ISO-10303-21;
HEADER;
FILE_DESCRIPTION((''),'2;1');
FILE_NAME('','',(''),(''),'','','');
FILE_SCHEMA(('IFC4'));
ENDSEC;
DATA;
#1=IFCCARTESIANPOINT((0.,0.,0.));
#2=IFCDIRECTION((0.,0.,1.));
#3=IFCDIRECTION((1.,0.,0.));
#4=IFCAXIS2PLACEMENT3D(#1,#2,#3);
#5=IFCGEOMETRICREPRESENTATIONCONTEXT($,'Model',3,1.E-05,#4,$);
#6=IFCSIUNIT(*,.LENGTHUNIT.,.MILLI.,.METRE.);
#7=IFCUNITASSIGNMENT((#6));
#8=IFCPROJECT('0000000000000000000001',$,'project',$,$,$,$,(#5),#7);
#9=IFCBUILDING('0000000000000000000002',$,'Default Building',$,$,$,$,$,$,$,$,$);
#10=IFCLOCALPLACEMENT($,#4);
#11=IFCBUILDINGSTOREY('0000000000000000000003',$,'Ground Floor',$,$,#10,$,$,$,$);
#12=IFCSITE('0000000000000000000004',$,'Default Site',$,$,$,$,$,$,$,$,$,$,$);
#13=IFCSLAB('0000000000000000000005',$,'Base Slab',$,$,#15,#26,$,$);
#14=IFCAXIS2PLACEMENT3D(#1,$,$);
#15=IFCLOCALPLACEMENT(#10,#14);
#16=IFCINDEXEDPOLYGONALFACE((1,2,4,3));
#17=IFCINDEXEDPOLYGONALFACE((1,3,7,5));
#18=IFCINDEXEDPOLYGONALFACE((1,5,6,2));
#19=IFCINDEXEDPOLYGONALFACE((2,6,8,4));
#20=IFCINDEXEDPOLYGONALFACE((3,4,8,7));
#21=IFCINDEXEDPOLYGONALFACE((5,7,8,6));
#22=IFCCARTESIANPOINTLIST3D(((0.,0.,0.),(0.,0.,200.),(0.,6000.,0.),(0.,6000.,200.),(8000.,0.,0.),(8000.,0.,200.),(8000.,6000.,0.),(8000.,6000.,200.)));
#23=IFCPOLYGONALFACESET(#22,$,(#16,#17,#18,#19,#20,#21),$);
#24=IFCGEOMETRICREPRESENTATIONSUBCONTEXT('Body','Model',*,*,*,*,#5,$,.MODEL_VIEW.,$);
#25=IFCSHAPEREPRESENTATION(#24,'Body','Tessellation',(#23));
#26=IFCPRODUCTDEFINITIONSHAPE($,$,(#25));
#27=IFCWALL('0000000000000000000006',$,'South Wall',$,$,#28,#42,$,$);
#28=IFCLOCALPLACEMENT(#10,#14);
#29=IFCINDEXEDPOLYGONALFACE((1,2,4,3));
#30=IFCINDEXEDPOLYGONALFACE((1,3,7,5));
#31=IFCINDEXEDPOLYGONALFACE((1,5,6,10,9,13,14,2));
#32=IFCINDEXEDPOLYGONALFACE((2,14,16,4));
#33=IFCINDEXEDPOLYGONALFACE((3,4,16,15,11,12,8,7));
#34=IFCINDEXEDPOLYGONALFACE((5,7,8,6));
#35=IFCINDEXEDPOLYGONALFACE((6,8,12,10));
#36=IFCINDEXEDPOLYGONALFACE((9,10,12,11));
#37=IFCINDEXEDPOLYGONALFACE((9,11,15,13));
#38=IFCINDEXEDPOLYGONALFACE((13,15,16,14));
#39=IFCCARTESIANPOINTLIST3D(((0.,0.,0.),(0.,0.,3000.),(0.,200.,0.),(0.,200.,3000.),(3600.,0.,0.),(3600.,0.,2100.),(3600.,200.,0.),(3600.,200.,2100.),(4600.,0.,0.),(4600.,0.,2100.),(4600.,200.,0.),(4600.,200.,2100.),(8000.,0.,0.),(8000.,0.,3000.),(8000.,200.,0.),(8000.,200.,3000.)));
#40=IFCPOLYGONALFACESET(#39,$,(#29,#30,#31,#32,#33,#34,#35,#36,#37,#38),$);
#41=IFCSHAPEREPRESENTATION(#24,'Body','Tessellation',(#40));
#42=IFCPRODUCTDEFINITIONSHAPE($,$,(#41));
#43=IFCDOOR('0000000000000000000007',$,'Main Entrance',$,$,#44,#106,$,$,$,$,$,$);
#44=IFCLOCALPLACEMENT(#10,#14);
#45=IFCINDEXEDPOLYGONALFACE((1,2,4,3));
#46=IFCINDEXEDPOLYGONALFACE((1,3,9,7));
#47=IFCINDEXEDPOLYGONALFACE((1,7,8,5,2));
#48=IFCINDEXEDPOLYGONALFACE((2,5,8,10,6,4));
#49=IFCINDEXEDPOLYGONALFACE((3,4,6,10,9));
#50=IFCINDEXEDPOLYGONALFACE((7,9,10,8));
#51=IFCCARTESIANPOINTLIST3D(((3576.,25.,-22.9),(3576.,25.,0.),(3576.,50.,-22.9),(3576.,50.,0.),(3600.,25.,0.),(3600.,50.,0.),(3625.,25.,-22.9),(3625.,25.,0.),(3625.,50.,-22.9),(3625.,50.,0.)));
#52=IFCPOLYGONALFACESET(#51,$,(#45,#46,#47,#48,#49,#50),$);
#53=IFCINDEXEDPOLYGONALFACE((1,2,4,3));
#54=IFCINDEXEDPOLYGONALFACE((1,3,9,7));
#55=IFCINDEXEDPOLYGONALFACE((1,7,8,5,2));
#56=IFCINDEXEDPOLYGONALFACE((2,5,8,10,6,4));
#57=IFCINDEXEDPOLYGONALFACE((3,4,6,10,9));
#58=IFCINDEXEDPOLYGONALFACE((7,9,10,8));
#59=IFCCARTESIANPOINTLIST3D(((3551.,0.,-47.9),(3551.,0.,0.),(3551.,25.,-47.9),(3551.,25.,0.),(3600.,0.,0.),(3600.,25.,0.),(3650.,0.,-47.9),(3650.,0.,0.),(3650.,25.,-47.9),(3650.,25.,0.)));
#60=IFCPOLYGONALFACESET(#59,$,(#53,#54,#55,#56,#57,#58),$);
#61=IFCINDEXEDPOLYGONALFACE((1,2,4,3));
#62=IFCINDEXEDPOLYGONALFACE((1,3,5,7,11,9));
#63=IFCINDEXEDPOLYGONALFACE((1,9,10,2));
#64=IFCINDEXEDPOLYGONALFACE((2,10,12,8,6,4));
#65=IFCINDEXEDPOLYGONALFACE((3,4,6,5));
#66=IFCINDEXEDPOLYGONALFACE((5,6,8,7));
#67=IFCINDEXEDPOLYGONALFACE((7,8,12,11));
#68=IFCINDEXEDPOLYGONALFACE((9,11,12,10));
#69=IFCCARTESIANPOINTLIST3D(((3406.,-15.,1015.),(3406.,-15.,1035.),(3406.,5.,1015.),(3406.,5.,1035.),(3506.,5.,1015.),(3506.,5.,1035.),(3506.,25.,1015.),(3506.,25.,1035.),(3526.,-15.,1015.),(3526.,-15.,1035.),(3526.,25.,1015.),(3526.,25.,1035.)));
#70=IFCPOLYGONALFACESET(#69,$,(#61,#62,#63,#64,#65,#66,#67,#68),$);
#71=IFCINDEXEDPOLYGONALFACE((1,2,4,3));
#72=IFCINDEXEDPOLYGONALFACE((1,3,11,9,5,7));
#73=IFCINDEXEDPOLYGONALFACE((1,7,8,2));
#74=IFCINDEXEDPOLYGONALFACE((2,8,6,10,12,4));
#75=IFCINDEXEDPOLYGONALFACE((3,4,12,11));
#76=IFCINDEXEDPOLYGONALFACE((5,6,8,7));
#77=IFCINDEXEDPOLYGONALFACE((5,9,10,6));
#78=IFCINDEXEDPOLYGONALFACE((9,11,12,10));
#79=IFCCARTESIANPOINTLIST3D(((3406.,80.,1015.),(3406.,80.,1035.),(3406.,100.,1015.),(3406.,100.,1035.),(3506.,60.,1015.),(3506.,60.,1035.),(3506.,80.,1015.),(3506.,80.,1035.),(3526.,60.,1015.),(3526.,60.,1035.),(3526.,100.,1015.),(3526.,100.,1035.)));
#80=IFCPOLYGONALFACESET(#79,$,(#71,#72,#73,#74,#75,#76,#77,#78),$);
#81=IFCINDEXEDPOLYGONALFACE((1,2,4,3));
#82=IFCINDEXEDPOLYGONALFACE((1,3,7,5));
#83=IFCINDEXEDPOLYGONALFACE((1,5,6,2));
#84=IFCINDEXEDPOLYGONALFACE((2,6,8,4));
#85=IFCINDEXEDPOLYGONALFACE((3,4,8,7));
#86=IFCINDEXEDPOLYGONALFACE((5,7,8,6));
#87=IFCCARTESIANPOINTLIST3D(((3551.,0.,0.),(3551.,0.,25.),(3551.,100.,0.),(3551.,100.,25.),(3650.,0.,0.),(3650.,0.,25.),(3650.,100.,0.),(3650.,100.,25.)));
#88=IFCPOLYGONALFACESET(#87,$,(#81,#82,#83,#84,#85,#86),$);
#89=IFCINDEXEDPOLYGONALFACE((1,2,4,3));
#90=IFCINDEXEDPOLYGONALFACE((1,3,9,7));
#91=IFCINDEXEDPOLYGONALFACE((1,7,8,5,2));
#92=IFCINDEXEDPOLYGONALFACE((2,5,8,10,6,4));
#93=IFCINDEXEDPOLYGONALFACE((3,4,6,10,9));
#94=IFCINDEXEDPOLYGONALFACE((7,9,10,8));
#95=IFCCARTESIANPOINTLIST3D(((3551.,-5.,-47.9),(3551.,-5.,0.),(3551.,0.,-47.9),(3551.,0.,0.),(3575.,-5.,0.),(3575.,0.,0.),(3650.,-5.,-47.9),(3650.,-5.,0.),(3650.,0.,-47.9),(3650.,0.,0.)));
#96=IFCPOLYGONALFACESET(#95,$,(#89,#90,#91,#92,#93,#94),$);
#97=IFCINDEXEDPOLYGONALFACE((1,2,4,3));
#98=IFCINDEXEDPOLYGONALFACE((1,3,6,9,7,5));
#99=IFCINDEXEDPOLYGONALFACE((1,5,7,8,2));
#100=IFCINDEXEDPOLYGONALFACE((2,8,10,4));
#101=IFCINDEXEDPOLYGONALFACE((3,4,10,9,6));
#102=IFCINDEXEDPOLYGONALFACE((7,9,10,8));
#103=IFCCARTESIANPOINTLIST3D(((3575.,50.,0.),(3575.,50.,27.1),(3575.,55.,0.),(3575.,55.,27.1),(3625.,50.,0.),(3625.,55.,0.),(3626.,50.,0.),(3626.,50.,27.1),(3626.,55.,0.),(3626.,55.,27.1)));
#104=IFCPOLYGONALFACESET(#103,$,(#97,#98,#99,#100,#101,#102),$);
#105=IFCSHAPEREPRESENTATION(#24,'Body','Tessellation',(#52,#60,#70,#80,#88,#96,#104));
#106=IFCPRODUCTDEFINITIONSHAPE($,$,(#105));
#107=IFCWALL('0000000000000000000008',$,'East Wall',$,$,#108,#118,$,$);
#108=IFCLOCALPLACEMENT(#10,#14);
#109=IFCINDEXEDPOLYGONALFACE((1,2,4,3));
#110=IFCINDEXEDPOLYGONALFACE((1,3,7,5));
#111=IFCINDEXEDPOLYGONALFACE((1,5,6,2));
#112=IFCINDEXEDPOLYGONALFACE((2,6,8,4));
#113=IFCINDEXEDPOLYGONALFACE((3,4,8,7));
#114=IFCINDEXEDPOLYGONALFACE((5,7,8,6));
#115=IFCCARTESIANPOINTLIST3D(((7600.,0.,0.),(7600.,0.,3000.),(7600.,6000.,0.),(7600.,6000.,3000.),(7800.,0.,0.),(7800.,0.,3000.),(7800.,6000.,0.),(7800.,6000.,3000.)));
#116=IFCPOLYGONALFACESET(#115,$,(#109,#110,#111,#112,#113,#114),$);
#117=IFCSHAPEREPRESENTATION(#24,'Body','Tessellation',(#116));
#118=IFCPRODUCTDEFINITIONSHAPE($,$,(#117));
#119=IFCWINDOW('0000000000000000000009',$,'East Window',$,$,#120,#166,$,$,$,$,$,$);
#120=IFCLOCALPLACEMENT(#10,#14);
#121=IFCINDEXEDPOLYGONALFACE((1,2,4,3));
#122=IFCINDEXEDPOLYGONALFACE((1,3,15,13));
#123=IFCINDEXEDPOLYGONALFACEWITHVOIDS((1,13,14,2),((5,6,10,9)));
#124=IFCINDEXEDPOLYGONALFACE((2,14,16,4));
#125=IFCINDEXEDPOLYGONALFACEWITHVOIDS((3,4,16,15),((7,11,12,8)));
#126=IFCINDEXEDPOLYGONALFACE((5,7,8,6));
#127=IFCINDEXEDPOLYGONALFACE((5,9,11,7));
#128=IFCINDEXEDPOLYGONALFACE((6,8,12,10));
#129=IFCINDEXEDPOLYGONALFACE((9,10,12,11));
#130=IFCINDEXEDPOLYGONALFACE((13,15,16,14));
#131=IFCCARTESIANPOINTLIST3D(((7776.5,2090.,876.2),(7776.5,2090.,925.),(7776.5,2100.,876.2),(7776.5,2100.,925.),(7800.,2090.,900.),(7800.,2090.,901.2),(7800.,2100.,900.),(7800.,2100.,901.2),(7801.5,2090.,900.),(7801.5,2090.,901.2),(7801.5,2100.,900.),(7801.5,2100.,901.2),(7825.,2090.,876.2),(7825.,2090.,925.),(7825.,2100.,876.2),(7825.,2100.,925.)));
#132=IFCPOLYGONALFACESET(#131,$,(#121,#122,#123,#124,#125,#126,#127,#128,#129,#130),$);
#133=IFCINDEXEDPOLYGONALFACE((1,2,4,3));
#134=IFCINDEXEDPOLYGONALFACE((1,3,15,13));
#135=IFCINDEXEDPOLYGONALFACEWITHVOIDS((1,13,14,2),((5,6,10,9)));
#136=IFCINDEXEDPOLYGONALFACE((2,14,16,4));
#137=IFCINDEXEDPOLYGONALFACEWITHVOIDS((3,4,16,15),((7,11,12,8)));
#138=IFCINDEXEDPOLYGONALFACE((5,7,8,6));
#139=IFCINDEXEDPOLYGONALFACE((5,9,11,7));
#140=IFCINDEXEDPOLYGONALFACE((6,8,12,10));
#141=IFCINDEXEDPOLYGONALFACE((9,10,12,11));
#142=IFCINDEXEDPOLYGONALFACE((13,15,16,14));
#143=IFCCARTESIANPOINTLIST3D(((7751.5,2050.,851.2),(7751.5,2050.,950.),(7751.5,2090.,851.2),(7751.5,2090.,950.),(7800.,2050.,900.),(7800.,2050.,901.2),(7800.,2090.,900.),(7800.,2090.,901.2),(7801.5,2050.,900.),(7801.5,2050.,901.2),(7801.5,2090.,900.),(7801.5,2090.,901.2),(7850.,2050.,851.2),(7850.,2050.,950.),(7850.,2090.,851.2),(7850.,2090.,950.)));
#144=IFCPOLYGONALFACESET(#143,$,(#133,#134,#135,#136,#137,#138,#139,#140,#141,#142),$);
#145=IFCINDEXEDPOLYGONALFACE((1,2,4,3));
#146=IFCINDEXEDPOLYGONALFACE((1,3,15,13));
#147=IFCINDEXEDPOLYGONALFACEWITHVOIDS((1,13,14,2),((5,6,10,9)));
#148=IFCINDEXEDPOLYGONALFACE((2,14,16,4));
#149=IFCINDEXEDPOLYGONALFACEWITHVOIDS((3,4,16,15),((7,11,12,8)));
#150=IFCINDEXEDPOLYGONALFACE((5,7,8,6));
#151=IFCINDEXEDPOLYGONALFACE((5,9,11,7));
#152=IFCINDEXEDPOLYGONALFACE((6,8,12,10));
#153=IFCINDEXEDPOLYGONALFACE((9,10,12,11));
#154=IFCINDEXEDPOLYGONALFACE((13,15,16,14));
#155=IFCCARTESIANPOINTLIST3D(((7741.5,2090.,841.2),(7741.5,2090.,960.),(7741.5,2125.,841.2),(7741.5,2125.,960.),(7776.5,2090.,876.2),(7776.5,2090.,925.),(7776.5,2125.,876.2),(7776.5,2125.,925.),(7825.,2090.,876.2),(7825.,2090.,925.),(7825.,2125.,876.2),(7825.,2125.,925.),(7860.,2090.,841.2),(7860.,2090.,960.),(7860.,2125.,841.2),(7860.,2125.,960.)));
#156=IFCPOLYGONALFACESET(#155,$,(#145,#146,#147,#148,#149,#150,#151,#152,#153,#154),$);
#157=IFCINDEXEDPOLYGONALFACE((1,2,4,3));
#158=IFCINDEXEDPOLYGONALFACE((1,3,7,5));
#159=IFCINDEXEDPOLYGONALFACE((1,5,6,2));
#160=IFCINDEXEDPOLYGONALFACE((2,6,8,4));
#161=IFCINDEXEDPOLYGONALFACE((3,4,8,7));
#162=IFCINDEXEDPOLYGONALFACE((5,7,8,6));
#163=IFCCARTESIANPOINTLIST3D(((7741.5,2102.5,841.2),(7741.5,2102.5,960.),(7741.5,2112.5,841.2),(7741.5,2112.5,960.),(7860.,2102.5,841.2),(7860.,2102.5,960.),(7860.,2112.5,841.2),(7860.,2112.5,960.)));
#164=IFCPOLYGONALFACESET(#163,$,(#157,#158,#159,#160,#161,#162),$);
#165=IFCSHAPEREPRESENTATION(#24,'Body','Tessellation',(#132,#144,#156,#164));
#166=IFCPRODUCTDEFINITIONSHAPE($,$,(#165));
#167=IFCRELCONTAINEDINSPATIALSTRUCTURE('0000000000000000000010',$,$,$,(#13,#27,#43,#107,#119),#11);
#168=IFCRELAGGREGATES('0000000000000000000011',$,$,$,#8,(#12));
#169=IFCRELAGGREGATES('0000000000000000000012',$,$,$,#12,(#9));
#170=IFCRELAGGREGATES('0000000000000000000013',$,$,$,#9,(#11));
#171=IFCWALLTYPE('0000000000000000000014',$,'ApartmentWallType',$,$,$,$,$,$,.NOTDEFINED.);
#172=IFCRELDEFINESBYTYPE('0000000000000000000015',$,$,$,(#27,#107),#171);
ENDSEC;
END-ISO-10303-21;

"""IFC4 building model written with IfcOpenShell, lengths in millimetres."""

from ifc_helpers import new_model, si_unit, frame, origin_with_axes, place, context, subcontext, project, spatial, line, indexed_curve, outline, extrude, type_object, element, fill, save


model = new_model("IFC4")

# Units and contexts
model_context = context("Model", 3, precision=1e-05, world=origin_with_axes())
body_context = subcontext(model_context, "Body", "Model", "MODEL_VIEW")
ifc_project = project(units=[si_unit("LENGTHUNIT", "METRE", prefix="MILLI")], contexts=[model_context])

# Site, building, storey
site = spatial("IfcSite", under=ifc_project, Name="Default Site")
building = spatial("IfcBuilding", under=site, Name="Default Building")
storey_placement = place(None, origin_with_axes())
storey = spatial("IfcBuildingStorey", under=building, at=storey_placement, Name="Ground Floor")

# Slab
slab_placement = place(storey_placement, origin_with_axes())
element("IfcSlab", 1, at=slab_placement, inside=storey, Name="Base Slab", context=body_context, shape_type="SweptSolid", body=[
    extrude(outline(indexed_curve([(0.0, 0.0), (8000.0, 0.0), (8000.0, 6000.0), (0.0, 6000.0), (0.0, 0.0)])), None, (0.0, 0.0, 1.0), 200.0),
])

# Wall, opening, door
wall_type = type_object("IfcWallType", Name="ApartmentWallType", PredefinedType="NOTDEFINED")
wall_1_placement = place(storey_placement, origin_with_axes())
wall_1 = element("IfcWall", 2, at=wall_1_placement, inside=storey, type_object=wall_type, Name="South Wall", context=body_context, shape_type="SweptSolid", body=[
    extrude(outline(indexed_curve([(0.0, 0.0), (8000.0, 0.0), (8000.0, 200.0), (0.0, 200.0), (0.0, 0.0)])), None, (0.0, 0.0, 1.0), 3000.0),
])
opening_1_placement = place(wall_1_placement, origin_with_axes())
opening_1 = element("IfcOpeningElement", 3, at=opening_1_placement, cuts=wall_1, context=body_context, shape_type="SweptSolid", body=[
    extrude(outline(indexed_curve([(3600.0, 0.0), (4600.0, 0.0), (4600.0, 200.0), (3600.0, 200.0), (3600.0, 0.0)])), None, (0.0, 0.0, 1.0), 2100.0),
])
door_1_placement = place(storey_placement, frame((3600.0, 0.0, 0.0), z_axis=(0.0, 0.0, 1.0), x_axis=(1.0, 0.0, 0.0)))
door_1 = element("IfcDoor", 4, at=door_1_placement, inside=storey, Name="Main Entrance", context=body_context, shape_type="SweptSolid", body=[
    extrude(outline(indexed_curve([(0.0, 0.0), (0.0, 2.1), (1.0, 2.1), (1.0, 0.0), (-24.0, 0.0), (-24.0, -22.9), (25.0, -22.9), (25.0, 0.0)], segments=[line(1, 2, 3, 4, 5, 6, 7, 8, 1)])), frame((0.0, 25.0, 0.0), z_axis=(0.0, -1.0, 0.0), x_axis=(1.0, 0.0, 0.0)), (0.0, 0.0, -1.0), 25.0),
    extrude(outline(indexed_curve([(0.0, 0.0), (0.0, 2.1), (1.0, 2.1), (1.0, 0.0), (-49.0, 0.0), (-49.0, -47.9), (50.0, -47.9), (50.0, 0.0)], segments=[line(1, 2, 3, 4, 5, 6, 7, 8, 1)])), frame((0.0, 0.0, 0.0), z_axis=(0.0, -1.0, 0.0), x_axis=(1.0, 0.0, 0.0)), (0.0, 0.0, -1.0), 25.0),
    extrude(outline(indexed_curve([(0.0, 0.0), (-49.0, 0.0), (-49.0, 35.0), (0.0, 35.0)], segments=[line(1, 2, 3, 4, 1)])), frame((25.0, 25.0, 25.0), z_axis=(0.0, 0.0, 1.0), x_axis=(1.0, 0.0, 0.0)), (0.0, 0.0, 1.0), -47.9),
    extrude(outline(indexed_curve([(0.0, 0.0), (0.0, -40.0), (-120.0, -40.0), (-120.0, -20.0), (-20.0, -20.0), (-20.0, 0.0)], segments=[line(1, 2, 3, 4, 5, 6, 1)])), frame((-74.0, 25.0, 1015.0), z_axis=(0.0, 0.0, 1.0), x_axis=(1.0, 0.0, 0.0)), (0.0, 0.0, 1.0), 20.0),
    extrude(outline(indexed_curve([(0.0, 0.0), (0.0, 40.0), (-120.0, 40.0), (-120.0, 20.0), (-20.0, 20.0), (-20.0, 0.0)], segments=[line(1, 2, 3, 4, 5, 6, 1)])), frame((-74.0, 60.0, 1015.0), z_axis=(0.0, 0.0, 1.0), x_axis=(1.0, 0.0, 0.0)), (0.0, 0.0, 1.0), 20.0),
    extrude(outline(indexed_curve([(0.0, 0.0), (-99.0, 0.0), (-99.0, 100.0), (0.0, 100.0)], segments=[line(1, 2, 3, 4, 1)])), frame((50.0, 0.0, 0.0), z_axis=(0.0, 0.0, 1.0), x_axis=(1.0, 0.0, 0.0)), (0.0, 0.0, 1.0), 25.0),
    extrude(outline(indexed_curve([(0.0, 0.0), (0.0, 27.1), (51.0, 27.1), (51.0, 0.0), (-24.0, 0.0), (-24.0, -47.9), (75.0, -47.9), (75.0, 0.0)], segments=[line(1, 2, 3, 4, 5, 6, 7, 8, 1)])), frame((-25.0, -5.0, 0.0), z_axis=(0.0, -1.0, 0.0), x_axis=(1.0, 0.0, 0.0)), (0.0, 0.0, -1.0), 5.0),
    extrude(outline(indexed_curve([(0.0, 0.0), (0.0, 27.1), (51.0, 27.1), (51.0, 0.0), (1.0, 0.0), (1.0, -22.9), (50.0, -22.9), (50.0, 0.0)], segments=[line(1, 2, 3, 4, 5, 6, 7, 8, 1)])), frame((-25.0, 50.0, 0.0), z_axis=(0.0, -1.0, 0.0), x_axis=(1.0, 0.0, 0.0)), (0.0, 0.0, -1.0), 5.0),
])
fill(opening_1, door_1)

# Wall, opening, window
wall_2_placement = place(storey_placement, origin_with_axes())
wall_2 = element("IfcWall", 5, at=wall_2_placement, inside=storey, type_object=wall_type, Name="East Wall", context=body_context, shape_type="SweptSolid", body=[
    extrude(outline(indexed_curve([(7800.0, 0.0), (7800.0, 6000.0), (7600.0, 6000.0), (7600.0, 0.0), (7800.0, 0.0)])), None, (0.0, 0.0, 1.0), 3000.0),
])
opening_2_placement = place(wall_2_placement, frame((0.0, 0.0, 900.0), z_axis=(0.0, 0.0, 1.0), x_axis=(1.0, 0.0, 0.0)))
opening_2 = element("IfcOpeningElement", 6, at=opening_2_placement, cuts=wall_2, context=body_context, shape_type="SweptSolid", body=[
    extrude(outline(indexed_curve([(7800.0, 2000.0), (9300.0, 2000.0), (9300.0, 2200.0), (7800.0, 2200.0), (7800.0, 2000.0)])), None, (0.0, 0.0, 1.0), 1200.0),
])
window_1_placement = place(storey_placement, frame((7800.0, 2000.0, 900.0), z_axis=(0.0, 0.0, 1.0), x_axis=(1.0, 0.0, 0.0)))
window_1 = element("IfcWindow", 7, at=window_1_placement, inside=storey, Name="East Window", context=body_context, shape_type="SweptSolid", body=[
    extrude(outline(indexed_curve([(0.0, 0.0), (1.5, 0.0), (1.5, 1.2), (0.0, 1.2)], segments=[line(1, 2, 3, 4, 1)]), holes=[indexed_curve([(25.0, 25.0), (-23.5, 25.0), (-23.5, -23.8), (25.0, -23.8)], segments=[line(1, 2, 3, 4, 1)])]), frame((0.0, 90.0, 0.0), z_axis=(0.0, -1.0, 0.0), x_axis=(1.0, 0.0, 0.0)), (0.0, 0.0, -1.0), 10.0),
    extrude(outline(indexed_curve([(0.0, 0.0), (1.5, 0.0), (1.5, 1.2), (0.0, 1.2)], segments=[line(1, 2, 3, 4, 1)]), holes=[indexed_curve([(50.0, 50.0), (-48.5, 50.0), (-48.5, -48.8), (50.0, -48.8)], segments=[line(1, 2, 3, 4, 1)])]), frame((0.0, 50.0, 0.0), z_axis=(0.0, -1.0, 0.0), x_axis=(1.0, 0.0, 0.0)), (0.0, 0.0, -1.0), 40.0),
    extrude(outline(indexed_curve([(0.0, 0.0), (-48.5, 0.0), (-48.5, -48.8), (0.0, -48.8)], segments=[line(1, 2, 3, 4, 1)]), holes=[indexed_curve([(35.0, 35.0), (-83.5, 35.0), (-83.5, -83.8), (35.0, -83.8)], segments=[line(1, 2, 3, 4, 1)])]), frame((25.0, 90.0, 25.0), z_axis=(0.0, -1.0, 0.0), x_axis=(1.0, 0.0, 0.0)), (0.0, 0.0, -1.0), 35.0),
    extrude(outline(indexed_curve([(35.0, 35.0), (-83.5, 35.0), (-83.5, -83.8), (35.0, -83.8)], segments=[line(1, 2, 3, 4, 1)])), frame((25.0, 102.5, 25.0), z_axis=(0.0, -1.0, 0.0), x_axis=(1.0, 0.0, 0.0)), (0.0, 0.0, -1.0), 10.0),
])
fill(opening_2, window_1)

save(model, "model.ifc")
